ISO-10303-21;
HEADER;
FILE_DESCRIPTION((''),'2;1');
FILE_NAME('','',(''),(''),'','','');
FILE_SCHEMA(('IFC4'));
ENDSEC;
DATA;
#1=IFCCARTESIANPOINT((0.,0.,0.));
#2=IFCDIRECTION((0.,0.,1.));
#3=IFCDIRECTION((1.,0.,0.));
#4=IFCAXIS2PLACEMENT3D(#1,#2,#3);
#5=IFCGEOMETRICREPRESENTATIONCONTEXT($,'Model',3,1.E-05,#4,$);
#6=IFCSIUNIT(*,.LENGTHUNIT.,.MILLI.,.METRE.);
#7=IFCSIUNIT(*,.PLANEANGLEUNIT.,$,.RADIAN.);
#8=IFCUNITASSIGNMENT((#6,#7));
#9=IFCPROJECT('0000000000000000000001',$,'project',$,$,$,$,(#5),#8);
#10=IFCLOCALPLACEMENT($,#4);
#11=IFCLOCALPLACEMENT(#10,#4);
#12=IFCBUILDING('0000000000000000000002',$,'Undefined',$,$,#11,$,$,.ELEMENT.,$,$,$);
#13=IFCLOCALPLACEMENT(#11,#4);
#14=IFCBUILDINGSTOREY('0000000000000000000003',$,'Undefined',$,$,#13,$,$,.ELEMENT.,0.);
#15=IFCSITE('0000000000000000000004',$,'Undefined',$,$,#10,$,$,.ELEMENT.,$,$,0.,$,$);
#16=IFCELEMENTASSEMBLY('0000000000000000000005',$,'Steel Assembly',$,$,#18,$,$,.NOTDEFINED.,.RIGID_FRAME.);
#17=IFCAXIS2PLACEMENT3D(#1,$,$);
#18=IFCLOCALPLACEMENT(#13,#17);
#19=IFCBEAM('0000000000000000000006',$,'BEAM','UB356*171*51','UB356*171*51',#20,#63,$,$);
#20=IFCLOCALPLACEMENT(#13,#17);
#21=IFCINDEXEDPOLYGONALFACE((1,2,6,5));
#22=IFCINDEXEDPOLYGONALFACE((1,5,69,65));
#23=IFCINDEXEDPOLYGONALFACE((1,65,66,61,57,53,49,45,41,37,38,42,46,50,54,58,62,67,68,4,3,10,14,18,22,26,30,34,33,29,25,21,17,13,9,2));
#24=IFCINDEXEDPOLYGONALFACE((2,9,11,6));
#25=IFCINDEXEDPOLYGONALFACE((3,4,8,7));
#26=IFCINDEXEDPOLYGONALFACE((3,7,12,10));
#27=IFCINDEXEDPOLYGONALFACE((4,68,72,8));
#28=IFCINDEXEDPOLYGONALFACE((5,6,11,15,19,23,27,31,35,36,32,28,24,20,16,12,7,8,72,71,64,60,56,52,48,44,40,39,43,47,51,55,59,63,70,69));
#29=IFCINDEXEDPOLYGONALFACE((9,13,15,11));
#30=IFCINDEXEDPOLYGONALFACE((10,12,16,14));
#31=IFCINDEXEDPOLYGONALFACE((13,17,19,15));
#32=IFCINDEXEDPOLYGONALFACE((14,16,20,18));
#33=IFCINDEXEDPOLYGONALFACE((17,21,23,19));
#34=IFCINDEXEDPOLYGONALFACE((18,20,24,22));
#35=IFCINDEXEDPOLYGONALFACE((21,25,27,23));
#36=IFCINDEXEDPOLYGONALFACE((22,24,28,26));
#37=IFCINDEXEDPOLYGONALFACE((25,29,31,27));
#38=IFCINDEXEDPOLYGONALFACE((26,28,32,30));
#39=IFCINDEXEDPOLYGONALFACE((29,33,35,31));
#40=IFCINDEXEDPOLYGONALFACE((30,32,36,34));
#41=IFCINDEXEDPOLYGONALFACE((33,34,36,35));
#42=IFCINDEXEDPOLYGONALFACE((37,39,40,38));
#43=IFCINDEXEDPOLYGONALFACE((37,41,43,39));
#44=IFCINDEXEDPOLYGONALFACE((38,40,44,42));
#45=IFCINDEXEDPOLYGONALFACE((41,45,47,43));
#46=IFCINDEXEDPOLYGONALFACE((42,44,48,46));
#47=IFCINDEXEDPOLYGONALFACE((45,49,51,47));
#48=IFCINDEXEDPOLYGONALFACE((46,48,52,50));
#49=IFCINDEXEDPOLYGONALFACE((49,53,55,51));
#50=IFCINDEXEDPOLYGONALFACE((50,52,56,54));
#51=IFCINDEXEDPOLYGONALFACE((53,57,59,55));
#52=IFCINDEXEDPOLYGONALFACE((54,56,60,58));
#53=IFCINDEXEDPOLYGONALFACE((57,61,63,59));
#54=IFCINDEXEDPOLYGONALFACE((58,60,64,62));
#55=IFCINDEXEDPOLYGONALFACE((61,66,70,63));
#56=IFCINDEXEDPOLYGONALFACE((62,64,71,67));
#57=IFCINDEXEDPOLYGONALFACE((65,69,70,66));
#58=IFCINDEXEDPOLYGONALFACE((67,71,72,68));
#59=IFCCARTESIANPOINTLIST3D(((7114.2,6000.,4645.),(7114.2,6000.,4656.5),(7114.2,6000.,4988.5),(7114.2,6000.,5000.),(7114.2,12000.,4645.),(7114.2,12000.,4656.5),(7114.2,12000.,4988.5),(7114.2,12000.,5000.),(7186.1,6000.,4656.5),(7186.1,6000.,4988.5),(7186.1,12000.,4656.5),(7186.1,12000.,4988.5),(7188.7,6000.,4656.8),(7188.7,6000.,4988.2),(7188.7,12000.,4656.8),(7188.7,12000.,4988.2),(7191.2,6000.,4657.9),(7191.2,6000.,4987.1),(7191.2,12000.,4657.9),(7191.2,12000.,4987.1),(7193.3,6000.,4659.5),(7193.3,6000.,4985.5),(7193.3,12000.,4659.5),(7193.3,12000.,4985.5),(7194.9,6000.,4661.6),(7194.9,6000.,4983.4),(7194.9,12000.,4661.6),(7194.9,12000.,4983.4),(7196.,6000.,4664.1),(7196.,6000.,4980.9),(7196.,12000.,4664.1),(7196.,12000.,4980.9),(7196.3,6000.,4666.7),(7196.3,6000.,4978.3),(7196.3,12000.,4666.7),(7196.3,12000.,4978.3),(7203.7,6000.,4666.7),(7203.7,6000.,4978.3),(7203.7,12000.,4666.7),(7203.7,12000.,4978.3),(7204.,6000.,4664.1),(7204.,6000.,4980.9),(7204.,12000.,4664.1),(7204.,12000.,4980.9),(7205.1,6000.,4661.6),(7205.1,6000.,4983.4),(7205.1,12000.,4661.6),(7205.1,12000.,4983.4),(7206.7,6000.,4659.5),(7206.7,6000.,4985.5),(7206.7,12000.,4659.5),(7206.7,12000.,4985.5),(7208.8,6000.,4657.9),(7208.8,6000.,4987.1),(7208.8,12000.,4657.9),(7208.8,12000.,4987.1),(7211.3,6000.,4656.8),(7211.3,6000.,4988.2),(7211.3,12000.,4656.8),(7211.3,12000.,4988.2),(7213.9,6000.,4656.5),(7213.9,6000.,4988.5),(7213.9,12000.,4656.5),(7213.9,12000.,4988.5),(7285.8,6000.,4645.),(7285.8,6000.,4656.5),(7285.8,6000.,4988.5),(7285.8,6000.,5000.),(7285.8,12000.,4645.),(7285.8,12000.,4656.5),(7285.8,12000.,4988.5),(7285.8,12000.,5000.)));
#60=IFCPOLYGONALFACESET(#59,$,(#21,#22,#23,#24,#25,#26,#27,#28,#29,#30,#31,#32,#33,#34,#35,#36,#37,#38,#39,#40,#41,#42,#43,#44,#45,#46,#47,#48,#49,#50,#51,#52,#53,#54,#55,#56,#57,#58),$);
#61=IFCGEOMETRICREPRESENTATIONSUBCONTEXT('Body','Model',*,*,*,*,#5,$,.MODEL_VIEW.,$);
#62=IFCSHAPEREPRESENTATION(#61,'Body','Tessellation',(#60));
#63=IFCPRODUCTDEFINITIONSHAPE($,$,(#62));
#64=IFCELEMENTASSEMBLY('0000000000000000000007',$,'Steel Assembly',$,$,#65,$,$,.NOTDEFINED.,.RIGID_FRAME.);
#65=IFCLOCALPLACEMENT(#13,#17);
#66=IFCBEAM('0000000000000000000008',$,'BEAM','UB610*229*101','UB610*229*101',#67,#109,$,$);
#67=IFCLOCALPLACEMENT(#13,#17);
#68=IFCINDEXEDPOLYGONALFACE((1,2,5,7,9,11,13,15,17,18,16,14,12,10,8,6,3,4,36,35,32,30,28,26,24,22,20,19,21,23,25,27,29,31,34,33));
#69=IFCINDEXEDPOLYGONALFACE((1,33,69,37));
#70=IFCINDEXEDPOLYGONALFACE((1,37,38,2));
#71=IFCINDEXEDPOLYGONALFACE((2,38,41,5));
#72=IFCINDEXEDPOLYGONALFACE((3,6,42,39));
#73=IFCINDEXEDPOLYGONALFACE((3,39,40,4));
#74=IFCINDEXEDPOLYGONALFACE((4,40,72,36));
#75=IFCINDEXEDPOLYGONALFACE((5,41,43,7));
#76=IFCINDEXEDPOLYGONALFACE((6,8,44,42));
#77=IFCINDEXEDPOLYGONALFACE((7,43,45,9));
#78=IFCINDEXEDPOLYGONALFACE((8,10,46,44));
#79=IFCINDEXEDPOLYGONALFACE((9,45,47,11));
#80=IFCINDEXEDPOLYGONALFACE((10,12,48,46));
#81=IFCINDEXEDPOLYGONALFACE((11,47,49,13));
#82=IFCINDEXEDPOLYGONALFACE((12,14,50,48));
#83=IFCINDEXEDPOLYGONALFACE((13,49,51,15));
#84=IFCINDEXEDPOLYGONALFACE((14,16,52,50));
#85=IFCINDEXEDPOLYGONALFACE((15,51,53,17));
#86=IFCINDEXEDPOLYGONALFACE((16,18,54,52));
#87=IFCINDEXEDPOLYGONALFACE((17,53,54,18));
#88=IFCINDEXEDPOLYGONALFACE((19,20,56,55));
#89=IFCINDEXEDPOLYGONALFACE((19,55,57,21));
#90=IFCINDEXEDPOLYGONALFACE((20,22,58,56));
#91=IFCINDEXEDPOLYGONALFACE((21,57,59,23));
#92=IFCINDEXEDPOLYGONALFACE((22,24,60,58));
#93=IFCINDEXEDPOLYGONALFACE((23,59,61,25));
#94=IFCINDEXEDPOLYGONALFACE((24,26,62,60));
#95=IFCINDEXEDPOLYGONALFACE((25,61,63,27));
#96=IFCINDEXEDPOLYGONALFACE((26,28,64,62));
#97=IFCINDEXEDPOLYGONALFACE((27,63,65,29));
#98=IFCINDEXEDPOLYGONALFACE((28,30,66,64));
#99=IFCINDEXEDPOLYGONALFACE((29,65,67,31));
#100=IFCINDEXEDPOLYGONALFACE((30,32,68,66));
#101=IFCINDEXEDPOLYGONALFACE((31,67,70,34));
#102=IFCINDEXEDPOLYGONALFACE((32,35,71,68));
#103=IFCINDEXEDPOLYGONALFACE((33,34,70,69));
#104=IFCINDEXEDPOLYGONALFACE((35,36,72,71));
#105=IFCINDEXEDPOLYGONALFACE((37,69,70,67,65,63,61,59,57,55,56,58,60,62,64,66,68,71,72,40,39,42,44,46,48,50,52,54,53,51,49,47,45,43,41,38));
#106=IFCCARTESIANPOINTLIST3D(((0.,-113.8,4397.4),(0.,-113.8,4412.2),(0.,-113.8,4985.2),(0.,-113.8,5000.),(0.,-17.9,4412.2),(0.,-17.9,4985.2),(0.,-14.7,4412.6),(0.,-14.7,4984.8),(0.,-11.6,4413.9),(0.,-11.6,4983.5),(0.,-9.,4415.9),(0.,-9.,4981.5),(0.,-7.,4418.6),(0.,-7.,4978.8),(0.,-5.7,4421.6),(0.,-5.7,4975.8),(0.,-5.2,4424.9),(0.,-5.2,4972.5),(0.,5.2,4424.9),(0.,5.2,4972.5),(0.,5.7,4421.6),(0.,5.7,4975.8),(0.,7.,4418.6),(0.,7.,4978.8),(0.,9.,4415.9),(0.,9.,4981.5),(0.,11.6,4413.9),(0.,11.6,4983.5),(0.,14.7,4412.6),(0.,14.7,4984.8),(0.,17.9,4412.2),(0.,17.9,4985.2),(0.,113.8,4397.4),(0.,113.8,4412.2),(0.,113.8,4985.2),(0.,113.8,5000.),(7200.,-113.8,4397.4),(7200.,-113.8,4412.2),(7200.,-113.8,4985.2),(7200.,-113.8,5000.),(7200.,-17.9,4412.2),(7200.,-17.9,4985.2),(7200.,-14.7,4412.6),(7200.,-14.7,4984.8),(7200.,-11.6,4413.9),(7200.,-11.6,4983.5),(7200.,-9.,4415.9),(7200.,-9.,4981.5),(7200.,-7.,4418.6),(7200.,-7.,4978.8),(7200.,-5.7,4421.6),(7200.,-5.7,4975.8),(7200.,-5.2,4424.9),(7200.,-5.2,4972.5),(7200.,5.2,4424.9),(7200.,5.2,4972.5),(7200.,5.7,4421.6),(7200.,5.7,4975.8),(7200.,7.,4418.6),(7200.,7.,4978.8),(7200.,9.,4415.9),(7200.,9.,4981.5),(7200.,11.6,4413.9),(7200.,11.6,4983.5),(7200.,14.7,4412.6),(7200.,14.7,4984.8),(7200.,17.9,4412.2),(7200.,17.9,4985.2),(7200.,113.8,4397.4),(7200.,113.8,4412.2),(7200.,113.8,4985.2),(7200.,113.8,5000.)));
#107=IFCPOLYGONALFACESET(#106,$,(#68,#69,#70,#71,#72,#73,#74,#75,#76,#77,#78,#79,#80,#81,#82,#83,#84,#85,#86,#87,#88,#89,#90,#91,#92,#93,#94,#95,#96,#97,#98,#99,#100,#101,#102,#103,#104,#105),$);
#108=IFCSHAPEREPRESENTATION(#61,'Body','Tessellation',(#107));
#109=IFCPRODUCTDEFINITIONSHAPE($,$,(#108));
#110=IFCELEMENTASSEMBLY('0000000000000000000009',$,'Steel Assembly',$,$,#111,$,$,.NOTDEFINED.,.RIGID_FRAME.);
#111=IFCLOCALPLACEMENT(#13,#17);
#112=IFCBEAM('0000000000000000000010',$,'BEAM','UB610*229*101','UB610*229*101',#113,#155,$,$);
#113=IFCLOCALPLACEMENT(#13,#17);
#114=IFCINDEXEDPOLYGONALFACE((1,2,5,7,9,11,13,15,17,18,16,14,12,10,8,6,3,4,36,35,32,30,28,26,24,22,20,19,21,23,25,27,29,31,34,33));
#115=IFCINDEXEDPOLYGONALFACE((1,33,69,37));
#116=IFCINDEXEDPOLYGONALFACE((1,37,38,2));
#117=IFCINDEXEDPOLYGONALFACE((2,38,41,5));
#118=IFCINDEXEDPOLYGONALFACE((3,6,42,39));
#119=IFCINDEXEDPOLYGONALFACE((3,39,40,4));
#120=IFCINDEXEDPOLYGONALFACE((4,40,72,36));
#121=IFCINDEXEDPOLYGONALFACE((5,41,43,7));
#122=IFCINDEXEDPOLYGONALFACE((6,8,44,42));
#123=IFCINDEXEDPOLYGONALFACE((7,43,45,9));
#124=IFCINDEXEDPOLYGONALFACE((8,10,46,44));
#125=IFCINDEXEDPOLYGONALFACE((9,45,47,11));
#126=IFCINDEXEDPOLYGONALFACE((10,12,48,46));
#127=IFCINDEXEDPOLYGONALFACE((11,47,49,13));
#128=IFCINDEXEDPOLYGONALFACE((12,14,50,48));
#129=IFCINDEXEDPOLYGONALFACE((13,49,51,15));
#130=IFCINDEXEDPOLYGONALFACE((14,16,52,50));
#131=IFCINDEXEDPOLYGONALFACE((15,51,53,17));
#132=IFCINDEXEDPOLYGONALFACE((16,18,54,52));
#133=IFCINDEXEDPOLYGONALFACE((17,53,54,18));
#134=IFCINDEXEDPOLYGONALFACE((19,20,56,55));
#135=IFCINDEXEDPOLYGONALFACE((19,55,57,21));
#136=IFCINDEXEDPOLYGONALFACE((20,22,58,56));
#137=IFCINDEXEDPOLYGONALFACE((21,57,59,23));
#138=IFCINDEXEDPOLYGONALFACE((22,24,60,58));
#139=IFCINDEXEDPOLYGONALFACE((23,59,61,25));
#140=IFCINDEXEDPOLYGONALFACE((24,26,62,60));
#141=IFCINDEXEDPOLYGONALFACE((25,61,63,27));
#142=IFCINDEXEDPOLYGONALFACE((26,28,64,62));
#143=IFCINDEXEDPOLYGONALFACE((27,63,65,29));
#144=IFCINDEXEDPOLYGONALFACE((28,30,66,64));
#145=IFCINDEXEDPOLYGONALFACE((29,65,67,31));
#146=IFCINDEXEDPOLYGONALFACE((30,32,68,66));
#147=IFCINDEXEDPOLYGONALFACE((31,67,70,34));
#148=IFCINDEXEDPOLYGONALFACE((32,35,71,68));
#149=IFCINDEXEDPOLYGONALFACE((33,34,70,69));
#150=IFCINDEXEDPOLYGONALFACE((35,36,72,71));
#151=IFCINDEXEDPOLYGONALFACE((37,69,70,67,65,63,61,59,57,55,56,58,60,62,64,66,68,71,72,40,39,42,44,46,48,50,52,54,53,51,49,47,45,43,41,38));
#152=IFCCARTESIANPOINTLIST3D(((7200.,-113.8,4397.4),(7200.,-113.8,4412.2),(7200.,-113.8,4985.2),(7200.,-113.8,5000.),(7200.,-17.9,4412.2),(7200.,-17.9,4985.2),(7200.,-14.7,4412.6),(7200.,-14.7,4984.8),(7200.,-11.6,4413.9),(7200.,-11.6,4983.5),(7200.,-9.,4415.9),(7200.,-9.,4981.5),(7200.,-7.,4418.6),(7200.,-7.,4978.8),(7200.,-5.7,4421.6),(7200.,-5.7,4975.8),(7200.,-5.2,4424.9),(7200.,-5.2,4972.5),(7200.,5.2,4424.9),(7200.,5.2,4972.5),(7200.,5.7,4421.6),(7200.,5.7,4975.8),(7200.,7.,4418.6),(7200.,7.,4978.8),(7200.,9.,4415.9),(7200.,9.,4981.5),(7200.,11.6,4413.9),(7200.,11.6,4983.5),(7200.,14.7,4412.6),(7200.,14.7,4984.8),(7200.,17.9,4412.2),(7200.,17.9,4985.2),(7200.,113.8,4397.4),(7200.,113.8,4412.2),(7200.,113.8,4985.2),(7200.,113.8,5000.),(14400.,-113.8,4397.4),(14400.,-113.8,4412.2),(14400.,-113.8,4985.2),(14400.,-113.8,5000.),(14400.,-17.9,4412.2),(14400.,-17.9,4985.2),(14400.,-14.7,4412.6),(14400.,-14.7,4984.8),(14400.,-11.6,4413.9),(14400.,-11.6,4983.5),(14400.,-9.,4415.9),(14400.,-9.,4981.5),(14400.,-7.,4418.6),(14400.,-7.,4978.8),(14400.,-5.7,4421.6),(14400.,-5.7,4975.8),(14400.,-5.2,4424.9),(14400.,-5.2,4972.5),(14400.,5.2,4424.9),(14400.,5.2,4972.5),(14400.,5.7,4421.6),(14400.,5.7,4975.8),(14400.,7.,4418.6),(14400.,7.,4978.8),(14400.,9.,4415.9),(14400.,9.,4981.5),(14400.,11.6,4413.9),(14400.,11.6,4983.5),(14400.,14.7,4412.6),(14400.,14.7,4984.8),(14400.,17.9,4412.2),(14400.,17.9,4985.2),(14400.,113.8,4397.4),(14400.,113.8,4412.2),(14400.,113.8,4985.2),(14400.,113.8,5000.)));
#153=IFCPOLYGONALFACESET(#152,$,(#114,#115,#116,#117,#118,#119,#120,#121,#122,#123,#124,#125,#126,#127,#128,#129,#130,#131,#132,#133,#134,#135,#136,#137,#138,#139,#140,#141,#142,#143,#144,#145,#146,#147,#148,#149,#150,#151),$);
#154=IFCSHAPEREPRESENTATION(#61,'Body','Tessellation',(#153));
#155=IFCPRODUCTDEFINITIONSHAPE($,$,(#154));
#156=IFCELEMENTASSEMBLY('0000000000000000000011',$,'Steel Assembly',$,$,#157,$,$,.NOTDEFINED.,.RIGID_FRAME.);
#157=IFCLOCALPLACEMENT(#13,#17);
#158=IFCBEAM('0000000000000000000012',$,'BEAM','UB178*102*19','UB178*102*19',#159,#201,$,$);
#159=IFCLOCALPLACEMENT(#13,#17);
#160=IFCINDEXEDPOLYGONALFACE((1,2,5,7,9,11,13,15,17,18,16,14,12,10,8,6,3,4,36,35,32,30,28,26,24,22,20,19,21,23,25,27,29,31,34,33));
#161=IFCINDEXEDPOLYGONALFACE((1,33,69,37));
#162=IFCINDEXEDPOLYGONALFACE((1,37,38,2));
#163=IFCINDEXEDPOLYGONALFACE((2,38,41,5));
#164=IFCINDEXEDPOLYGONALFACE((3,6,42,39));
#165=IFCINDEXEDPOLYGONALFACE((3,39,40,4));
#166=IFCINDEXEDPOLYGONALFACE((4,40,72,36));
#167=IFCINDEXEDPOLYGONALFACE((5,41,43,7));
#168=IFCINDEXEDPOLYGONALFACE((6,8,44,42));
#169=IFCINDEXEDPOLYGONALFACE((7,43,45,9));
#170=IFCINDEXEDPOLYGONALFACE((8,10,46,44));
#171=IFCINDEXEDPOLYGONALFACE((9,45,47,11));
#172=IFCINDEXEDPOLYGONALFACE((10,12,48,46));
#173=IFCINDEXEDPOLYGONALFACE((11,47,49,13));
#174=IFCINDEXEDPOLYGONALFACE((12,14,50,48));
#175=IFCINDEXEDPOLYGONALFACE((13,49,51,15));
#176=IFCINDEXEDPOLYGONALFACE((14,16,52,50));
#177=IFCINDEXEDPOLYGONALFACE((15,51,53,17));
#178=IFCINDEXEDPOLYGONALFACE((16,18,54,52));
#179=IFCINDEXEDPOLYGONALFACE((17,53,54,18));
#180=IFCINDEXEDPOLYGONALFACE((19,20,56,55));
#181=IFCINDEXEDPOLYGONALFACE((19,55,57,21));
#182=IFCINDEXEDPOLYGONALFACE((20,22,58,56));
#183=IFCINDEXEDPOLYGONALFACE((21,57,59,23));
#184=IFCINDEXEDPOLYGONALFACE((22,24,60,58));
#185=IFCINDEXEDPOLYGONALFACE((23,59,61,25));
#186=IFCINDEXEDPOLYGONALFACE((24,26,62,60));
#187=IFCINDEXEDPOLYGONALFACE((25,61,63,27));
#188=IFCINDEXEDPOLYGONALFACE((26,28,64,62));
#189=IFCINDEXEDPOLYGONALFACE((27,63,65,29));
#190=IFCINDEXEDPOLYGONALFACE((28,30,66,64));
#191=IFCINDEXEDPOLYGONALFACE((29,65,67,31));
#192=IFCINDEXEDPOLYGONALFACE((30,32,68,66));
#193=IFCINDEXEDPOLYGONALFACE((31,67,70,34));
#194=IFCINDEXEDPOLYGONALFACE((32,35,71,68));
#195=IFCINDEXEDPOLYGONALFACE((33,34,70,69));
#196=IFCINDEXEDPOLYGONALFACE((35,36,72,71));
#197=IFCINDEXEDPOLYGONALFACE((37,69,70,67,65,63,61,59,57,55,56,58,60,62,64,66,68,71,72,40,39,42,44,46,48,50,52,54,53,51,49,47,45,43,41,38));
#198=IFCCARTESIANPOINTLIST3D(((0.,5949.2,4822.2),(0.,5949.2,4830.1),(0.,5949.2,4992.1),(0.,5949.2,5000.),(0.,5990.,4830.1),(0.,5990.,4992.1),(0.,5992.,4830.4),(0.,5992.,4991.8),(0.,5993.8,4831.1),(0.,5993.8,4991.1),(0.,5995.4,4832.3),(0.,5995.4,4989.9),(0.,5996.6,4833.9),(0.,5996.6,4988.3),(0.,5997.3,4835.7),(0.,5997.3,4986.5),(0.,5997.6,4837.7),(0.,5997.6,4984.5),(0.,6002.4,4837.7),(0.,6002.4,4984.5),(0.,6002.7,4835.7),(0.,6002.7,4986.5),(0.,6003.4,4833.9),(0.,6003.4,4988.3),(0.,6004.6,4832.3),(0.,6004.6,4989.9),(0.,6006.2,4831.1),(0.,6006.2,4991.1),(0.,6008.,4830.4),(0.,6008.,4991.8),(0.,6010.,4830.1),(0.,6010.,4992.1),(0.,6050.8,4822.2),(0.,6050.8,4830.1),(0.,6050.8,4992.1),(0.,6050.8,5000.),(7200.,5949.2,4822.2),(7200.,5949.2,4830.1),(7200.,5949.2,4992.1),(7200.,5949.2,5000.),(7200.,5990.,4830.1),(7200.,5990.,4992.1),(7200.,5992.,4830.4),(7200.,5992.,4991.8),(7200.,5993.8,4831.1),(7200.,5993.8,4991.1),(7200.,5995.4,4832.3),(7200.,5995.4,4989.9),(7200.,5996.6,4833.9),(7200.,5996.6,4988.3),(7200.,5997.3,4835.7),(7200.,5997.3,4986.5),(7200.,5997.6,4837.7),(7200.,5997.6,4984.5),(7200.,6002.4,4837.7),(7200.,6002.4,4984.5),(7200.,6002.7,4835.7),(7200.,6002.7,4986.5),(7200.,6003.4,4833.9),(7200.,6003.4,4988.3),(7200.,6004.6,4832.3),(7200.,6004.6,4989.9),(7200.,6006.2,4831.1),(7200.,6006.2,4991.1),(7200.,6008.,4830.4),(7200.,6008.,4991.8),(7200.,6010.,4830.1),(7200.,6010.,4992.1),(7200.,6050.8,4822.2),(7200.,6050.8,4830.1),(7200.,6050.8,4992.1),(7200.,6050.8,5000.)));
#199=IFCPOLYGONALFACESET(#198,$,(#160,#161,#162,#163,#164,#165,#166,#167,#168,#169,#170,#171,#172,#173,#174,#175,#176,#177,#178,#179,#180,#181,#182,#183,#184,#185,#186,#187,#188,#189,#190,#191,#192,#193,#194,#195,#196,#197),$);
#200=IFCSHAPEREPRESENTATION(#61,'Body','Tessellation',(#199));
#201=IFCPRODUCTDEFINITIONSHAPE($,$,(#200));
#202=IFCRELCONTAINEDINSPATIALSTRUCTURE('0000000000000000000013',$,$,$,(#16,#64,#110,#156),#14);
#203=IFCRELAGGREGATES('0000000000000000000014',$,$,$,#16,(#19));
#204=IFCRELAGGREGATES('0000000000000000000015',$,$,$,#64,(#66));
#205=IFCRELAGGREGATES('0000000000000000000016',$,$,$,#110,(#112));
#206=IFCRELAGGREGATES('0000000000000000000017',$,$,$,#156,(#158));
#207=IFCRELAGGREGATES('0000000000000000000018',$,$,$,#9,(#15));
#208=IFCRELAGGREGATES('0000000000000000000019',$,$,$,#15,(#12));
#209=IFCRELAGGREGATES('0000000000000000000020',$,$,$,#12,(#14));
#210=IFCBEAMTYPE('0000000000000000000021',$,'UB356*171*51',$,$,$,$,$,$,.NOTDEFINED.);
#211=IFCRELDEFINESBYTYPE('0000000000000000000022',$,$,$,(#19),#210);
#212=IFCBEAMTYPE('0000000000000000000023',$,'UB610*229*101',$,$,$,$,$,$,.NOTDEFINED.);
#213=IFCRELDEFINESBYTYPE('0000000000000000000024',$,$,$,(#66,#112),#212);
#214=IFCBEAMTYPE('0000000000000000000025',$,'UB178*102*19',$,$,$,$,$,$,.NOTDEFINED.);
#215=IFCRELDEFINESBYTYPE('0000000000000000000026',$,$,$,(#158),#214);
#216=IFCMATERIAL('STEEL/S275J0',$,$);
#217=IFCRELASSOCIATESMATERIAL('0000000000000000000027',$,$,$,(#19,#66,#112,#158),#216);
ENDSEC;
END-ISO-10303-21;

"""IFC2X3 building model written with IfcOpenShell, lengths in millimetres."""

from ifc_helpers import new_model, si_unit, frame, origin_with_axes, origin_2d_with_axis, place, context, subcontext, project, spatial, i_section, extrude, material, type_object, element, aggregate, save


model = new_model("IFC2X3")

# Units and contexts
model_context = context("Model", 3, precision=1e-05, world=origin_with_axes())
body_context = subcontext(model_context, "Body", "Model", "MODEL_VIEW")
ifc_project = project(units=[si_unit("LENGTHUNIT", "METRE", prefix="MILLI"), si_unit("PLANEANGLEUNIT", "RADIAN")], contexts=[model_context])

# Site, building, storey
site_placement = place(None, origin_with_axes())
site = spatial("IfcSite", under=ifc_project, at=site_placement, Name="Undefined", CompositionType="ELEMENT", RefElevation=0.0)
building_placement = place(site_placement, origin_with_axes())
building = spatial("IfcBuilding", under=site, at=building_placement, Name="Undefined", CompositionType="ELEMENT")
storey_placement = place(building_placement, origin_with_axes())
storey = spatial("IfcBuildingStorey", under=building, at=storey_placement, Name="Undefined", CompositionType="ELEMENT", Elevation=0.0)

# Shared definitions
ifc_material = material(Name="STEEL/S275J0")

# Element assemblies, beams
beam_type_1 = type_object("IfcBeamType", Name="UB356*171*51", PredefinedType="NOTDEFINED")
assembly_1_placement = place(storey_placement, origin_with_axes())
assembly_1 = element("IfcElementAssembly", 1, at=assembly_1_placement, inside=storey, Name="Steel Assembly", AssemblyPlace="NOTDEFINED", PredefinedType="RIGID_FRAME")
beam_1_placement = place(assembly_1_placement, frame((7200.0, 6000.0, 4822.5), z_axis=(0.0, 0.0, 1.0), x_axis=(0.0, 1.0, 0.0)))
beam_1 = element("IfcBeam", 2, at=beam_1_placement, type_object=beam_type_1, material=ifc_material, Name="BEAM", Description="UB356*171*51", ObjectType="UB356*171*51", context=body_context, shape_type="SweptSolid", body=[
    extrude(i_section(OverallWidth=171.5, OverallDepth=355.0, WebThickness=7.4, FlangeThickness=11.5, FilletRadius=10.2, at=origin_2d_with_axis()), frame((6000.0, 0.0, 0.0), z_axis=(-1.0, 0.0, 0.0), x_axis=(0.0, -1.0, 0.0)), (0.0, 0.0, 1.0), 6000.0),
])
aggregate(assembly_1, [beam_1])
assembly_2_placement = place(storey_placement, origin_with_axes())
assembly_2 = element("IfcElementAssembly", 3, at=assembly_2_placement, inside=storey, Name="Steel Assembly", AssemblyPlace="NOTDEFINED", PredefinedType="RIGID_FRAME")
beam_type_2 = type_object("IfcBeamType", Name="UB610*229*101", PredefinedType="NOTDEFINED")
beam_2_placement = place(assembly_2_placement, frame((0.0, 0.0, 4698.7), z_axis=(0.0, 0.0, 1.0), x_axis=(1.0, 0.0, 0.0)))
beam_2 = element("IfcBeam", 4, at=beam_2_placement, type_object=beam_type_2, material=ifc_material, Name="BEAM", Description="UB610*229*101", ObjectType="UB610*229*101", context=body_context, shape_type="SweptSolid", body=[
    extrude(i_section(OverallWidth=227.6, OverallDepth=602.6, WebThickness=10.5, FlangeThickness=14.8, FilletRadius=12.7, at=origin_2d_with_axis()), frame((7200.0, 0.0, 0.0), z_axis=(-1.0, 0.0, 0.0), x_axis=(0.0, -1.0, 0.0)), (0.0, 0.0, 1.0), 7200.0),
])
aggregate(assembly_2, [beam_2])
assembly_3_placement = place(storey_placement, origin_with_axes())
assembly_3 = element("IfcElementAssembly", 5, at=assembly_3_placement, inside=storey, Name="Steel Assembly", AssemblyPlace="NOTDEFINED", PredefinedType="RIGID_FRAME")
beam_3_placement = place(assembly_3_placement, frame((7200.0, 0.0, 4698.7), z_axis=(0.0, 0.0, 1.0), x_axis=(1.0, 0.0, 0.0)))
beam_3 = element("IfcBeam", 6, at=beam_3_placement, type_object=beam_type_2, material=ifc_material, Name="BEAM", Description="UB610*229*101", ObjectType="UB610*229*101", context=body_context, shape_type="SweptSolid", body=[
    extrude(i_section(OverallWidth=227.6, OverallDepth=602.6, WebThickness=10.5, FlangeThickness=14.8, FilletRadius=12.7, at=origin_2d_with_axis()), frame((7200.0, 0.0, 0.0), z_axis=(-1.0, 0.0, 0.0), x_axis=(0.0, -1.0, 0.0)), (0.0, 0.0, 1.0), 7200.0),
])
aggregate(assembly_3, [beam_3])
assembly_4_placement = place(storey_placement, origin_with_axes())
assembly_4 = element("IfcElementAssembly", 7, at=assembly_4_placement, inside=storey, Name="Steel Assembly", AssemblyPlace="NOTDEFINED", PredefinedType="RIGID_FRAME")
beam_type_3 = type_object("IfcBeamType", Name="UB178*102*19", PredefinedType="NOTDEFINED")
beam_4_placement = place(assembly_4_placement, frame((0.0, 6000.0, 4911.1), z_axis=(0.0, 0.0, 1.0), x_axis=(1.0, 0.0, 0.0)))
beam_4 = element("IfcBeam", 8, at=beam_4_placement, type_object=beam_type_3, material=ifc_material, Name="BEAM", Description="UB178*102*19", ObjectType="UB178*102*19", context=body_context, shape_type="SweptSolid", body=[
    extrude(i_section(OverallWidth=101.6, OverallDepth=177.8, WebThickness=4.8, FlangeThickness=7.9, FilletRadius=7.6, at=origin_2d_with_axis()), frame((7200.0, 0.0, 0.0), z_axis=(-1.0, 0.0, 0.0), x_axis=(0.0, -1.0, 0.0)), (0.0, 0.0, 1.0), 7200.0),
])
aggregate(assembly_4, [beam_4])

save(model, "model.ifc")
